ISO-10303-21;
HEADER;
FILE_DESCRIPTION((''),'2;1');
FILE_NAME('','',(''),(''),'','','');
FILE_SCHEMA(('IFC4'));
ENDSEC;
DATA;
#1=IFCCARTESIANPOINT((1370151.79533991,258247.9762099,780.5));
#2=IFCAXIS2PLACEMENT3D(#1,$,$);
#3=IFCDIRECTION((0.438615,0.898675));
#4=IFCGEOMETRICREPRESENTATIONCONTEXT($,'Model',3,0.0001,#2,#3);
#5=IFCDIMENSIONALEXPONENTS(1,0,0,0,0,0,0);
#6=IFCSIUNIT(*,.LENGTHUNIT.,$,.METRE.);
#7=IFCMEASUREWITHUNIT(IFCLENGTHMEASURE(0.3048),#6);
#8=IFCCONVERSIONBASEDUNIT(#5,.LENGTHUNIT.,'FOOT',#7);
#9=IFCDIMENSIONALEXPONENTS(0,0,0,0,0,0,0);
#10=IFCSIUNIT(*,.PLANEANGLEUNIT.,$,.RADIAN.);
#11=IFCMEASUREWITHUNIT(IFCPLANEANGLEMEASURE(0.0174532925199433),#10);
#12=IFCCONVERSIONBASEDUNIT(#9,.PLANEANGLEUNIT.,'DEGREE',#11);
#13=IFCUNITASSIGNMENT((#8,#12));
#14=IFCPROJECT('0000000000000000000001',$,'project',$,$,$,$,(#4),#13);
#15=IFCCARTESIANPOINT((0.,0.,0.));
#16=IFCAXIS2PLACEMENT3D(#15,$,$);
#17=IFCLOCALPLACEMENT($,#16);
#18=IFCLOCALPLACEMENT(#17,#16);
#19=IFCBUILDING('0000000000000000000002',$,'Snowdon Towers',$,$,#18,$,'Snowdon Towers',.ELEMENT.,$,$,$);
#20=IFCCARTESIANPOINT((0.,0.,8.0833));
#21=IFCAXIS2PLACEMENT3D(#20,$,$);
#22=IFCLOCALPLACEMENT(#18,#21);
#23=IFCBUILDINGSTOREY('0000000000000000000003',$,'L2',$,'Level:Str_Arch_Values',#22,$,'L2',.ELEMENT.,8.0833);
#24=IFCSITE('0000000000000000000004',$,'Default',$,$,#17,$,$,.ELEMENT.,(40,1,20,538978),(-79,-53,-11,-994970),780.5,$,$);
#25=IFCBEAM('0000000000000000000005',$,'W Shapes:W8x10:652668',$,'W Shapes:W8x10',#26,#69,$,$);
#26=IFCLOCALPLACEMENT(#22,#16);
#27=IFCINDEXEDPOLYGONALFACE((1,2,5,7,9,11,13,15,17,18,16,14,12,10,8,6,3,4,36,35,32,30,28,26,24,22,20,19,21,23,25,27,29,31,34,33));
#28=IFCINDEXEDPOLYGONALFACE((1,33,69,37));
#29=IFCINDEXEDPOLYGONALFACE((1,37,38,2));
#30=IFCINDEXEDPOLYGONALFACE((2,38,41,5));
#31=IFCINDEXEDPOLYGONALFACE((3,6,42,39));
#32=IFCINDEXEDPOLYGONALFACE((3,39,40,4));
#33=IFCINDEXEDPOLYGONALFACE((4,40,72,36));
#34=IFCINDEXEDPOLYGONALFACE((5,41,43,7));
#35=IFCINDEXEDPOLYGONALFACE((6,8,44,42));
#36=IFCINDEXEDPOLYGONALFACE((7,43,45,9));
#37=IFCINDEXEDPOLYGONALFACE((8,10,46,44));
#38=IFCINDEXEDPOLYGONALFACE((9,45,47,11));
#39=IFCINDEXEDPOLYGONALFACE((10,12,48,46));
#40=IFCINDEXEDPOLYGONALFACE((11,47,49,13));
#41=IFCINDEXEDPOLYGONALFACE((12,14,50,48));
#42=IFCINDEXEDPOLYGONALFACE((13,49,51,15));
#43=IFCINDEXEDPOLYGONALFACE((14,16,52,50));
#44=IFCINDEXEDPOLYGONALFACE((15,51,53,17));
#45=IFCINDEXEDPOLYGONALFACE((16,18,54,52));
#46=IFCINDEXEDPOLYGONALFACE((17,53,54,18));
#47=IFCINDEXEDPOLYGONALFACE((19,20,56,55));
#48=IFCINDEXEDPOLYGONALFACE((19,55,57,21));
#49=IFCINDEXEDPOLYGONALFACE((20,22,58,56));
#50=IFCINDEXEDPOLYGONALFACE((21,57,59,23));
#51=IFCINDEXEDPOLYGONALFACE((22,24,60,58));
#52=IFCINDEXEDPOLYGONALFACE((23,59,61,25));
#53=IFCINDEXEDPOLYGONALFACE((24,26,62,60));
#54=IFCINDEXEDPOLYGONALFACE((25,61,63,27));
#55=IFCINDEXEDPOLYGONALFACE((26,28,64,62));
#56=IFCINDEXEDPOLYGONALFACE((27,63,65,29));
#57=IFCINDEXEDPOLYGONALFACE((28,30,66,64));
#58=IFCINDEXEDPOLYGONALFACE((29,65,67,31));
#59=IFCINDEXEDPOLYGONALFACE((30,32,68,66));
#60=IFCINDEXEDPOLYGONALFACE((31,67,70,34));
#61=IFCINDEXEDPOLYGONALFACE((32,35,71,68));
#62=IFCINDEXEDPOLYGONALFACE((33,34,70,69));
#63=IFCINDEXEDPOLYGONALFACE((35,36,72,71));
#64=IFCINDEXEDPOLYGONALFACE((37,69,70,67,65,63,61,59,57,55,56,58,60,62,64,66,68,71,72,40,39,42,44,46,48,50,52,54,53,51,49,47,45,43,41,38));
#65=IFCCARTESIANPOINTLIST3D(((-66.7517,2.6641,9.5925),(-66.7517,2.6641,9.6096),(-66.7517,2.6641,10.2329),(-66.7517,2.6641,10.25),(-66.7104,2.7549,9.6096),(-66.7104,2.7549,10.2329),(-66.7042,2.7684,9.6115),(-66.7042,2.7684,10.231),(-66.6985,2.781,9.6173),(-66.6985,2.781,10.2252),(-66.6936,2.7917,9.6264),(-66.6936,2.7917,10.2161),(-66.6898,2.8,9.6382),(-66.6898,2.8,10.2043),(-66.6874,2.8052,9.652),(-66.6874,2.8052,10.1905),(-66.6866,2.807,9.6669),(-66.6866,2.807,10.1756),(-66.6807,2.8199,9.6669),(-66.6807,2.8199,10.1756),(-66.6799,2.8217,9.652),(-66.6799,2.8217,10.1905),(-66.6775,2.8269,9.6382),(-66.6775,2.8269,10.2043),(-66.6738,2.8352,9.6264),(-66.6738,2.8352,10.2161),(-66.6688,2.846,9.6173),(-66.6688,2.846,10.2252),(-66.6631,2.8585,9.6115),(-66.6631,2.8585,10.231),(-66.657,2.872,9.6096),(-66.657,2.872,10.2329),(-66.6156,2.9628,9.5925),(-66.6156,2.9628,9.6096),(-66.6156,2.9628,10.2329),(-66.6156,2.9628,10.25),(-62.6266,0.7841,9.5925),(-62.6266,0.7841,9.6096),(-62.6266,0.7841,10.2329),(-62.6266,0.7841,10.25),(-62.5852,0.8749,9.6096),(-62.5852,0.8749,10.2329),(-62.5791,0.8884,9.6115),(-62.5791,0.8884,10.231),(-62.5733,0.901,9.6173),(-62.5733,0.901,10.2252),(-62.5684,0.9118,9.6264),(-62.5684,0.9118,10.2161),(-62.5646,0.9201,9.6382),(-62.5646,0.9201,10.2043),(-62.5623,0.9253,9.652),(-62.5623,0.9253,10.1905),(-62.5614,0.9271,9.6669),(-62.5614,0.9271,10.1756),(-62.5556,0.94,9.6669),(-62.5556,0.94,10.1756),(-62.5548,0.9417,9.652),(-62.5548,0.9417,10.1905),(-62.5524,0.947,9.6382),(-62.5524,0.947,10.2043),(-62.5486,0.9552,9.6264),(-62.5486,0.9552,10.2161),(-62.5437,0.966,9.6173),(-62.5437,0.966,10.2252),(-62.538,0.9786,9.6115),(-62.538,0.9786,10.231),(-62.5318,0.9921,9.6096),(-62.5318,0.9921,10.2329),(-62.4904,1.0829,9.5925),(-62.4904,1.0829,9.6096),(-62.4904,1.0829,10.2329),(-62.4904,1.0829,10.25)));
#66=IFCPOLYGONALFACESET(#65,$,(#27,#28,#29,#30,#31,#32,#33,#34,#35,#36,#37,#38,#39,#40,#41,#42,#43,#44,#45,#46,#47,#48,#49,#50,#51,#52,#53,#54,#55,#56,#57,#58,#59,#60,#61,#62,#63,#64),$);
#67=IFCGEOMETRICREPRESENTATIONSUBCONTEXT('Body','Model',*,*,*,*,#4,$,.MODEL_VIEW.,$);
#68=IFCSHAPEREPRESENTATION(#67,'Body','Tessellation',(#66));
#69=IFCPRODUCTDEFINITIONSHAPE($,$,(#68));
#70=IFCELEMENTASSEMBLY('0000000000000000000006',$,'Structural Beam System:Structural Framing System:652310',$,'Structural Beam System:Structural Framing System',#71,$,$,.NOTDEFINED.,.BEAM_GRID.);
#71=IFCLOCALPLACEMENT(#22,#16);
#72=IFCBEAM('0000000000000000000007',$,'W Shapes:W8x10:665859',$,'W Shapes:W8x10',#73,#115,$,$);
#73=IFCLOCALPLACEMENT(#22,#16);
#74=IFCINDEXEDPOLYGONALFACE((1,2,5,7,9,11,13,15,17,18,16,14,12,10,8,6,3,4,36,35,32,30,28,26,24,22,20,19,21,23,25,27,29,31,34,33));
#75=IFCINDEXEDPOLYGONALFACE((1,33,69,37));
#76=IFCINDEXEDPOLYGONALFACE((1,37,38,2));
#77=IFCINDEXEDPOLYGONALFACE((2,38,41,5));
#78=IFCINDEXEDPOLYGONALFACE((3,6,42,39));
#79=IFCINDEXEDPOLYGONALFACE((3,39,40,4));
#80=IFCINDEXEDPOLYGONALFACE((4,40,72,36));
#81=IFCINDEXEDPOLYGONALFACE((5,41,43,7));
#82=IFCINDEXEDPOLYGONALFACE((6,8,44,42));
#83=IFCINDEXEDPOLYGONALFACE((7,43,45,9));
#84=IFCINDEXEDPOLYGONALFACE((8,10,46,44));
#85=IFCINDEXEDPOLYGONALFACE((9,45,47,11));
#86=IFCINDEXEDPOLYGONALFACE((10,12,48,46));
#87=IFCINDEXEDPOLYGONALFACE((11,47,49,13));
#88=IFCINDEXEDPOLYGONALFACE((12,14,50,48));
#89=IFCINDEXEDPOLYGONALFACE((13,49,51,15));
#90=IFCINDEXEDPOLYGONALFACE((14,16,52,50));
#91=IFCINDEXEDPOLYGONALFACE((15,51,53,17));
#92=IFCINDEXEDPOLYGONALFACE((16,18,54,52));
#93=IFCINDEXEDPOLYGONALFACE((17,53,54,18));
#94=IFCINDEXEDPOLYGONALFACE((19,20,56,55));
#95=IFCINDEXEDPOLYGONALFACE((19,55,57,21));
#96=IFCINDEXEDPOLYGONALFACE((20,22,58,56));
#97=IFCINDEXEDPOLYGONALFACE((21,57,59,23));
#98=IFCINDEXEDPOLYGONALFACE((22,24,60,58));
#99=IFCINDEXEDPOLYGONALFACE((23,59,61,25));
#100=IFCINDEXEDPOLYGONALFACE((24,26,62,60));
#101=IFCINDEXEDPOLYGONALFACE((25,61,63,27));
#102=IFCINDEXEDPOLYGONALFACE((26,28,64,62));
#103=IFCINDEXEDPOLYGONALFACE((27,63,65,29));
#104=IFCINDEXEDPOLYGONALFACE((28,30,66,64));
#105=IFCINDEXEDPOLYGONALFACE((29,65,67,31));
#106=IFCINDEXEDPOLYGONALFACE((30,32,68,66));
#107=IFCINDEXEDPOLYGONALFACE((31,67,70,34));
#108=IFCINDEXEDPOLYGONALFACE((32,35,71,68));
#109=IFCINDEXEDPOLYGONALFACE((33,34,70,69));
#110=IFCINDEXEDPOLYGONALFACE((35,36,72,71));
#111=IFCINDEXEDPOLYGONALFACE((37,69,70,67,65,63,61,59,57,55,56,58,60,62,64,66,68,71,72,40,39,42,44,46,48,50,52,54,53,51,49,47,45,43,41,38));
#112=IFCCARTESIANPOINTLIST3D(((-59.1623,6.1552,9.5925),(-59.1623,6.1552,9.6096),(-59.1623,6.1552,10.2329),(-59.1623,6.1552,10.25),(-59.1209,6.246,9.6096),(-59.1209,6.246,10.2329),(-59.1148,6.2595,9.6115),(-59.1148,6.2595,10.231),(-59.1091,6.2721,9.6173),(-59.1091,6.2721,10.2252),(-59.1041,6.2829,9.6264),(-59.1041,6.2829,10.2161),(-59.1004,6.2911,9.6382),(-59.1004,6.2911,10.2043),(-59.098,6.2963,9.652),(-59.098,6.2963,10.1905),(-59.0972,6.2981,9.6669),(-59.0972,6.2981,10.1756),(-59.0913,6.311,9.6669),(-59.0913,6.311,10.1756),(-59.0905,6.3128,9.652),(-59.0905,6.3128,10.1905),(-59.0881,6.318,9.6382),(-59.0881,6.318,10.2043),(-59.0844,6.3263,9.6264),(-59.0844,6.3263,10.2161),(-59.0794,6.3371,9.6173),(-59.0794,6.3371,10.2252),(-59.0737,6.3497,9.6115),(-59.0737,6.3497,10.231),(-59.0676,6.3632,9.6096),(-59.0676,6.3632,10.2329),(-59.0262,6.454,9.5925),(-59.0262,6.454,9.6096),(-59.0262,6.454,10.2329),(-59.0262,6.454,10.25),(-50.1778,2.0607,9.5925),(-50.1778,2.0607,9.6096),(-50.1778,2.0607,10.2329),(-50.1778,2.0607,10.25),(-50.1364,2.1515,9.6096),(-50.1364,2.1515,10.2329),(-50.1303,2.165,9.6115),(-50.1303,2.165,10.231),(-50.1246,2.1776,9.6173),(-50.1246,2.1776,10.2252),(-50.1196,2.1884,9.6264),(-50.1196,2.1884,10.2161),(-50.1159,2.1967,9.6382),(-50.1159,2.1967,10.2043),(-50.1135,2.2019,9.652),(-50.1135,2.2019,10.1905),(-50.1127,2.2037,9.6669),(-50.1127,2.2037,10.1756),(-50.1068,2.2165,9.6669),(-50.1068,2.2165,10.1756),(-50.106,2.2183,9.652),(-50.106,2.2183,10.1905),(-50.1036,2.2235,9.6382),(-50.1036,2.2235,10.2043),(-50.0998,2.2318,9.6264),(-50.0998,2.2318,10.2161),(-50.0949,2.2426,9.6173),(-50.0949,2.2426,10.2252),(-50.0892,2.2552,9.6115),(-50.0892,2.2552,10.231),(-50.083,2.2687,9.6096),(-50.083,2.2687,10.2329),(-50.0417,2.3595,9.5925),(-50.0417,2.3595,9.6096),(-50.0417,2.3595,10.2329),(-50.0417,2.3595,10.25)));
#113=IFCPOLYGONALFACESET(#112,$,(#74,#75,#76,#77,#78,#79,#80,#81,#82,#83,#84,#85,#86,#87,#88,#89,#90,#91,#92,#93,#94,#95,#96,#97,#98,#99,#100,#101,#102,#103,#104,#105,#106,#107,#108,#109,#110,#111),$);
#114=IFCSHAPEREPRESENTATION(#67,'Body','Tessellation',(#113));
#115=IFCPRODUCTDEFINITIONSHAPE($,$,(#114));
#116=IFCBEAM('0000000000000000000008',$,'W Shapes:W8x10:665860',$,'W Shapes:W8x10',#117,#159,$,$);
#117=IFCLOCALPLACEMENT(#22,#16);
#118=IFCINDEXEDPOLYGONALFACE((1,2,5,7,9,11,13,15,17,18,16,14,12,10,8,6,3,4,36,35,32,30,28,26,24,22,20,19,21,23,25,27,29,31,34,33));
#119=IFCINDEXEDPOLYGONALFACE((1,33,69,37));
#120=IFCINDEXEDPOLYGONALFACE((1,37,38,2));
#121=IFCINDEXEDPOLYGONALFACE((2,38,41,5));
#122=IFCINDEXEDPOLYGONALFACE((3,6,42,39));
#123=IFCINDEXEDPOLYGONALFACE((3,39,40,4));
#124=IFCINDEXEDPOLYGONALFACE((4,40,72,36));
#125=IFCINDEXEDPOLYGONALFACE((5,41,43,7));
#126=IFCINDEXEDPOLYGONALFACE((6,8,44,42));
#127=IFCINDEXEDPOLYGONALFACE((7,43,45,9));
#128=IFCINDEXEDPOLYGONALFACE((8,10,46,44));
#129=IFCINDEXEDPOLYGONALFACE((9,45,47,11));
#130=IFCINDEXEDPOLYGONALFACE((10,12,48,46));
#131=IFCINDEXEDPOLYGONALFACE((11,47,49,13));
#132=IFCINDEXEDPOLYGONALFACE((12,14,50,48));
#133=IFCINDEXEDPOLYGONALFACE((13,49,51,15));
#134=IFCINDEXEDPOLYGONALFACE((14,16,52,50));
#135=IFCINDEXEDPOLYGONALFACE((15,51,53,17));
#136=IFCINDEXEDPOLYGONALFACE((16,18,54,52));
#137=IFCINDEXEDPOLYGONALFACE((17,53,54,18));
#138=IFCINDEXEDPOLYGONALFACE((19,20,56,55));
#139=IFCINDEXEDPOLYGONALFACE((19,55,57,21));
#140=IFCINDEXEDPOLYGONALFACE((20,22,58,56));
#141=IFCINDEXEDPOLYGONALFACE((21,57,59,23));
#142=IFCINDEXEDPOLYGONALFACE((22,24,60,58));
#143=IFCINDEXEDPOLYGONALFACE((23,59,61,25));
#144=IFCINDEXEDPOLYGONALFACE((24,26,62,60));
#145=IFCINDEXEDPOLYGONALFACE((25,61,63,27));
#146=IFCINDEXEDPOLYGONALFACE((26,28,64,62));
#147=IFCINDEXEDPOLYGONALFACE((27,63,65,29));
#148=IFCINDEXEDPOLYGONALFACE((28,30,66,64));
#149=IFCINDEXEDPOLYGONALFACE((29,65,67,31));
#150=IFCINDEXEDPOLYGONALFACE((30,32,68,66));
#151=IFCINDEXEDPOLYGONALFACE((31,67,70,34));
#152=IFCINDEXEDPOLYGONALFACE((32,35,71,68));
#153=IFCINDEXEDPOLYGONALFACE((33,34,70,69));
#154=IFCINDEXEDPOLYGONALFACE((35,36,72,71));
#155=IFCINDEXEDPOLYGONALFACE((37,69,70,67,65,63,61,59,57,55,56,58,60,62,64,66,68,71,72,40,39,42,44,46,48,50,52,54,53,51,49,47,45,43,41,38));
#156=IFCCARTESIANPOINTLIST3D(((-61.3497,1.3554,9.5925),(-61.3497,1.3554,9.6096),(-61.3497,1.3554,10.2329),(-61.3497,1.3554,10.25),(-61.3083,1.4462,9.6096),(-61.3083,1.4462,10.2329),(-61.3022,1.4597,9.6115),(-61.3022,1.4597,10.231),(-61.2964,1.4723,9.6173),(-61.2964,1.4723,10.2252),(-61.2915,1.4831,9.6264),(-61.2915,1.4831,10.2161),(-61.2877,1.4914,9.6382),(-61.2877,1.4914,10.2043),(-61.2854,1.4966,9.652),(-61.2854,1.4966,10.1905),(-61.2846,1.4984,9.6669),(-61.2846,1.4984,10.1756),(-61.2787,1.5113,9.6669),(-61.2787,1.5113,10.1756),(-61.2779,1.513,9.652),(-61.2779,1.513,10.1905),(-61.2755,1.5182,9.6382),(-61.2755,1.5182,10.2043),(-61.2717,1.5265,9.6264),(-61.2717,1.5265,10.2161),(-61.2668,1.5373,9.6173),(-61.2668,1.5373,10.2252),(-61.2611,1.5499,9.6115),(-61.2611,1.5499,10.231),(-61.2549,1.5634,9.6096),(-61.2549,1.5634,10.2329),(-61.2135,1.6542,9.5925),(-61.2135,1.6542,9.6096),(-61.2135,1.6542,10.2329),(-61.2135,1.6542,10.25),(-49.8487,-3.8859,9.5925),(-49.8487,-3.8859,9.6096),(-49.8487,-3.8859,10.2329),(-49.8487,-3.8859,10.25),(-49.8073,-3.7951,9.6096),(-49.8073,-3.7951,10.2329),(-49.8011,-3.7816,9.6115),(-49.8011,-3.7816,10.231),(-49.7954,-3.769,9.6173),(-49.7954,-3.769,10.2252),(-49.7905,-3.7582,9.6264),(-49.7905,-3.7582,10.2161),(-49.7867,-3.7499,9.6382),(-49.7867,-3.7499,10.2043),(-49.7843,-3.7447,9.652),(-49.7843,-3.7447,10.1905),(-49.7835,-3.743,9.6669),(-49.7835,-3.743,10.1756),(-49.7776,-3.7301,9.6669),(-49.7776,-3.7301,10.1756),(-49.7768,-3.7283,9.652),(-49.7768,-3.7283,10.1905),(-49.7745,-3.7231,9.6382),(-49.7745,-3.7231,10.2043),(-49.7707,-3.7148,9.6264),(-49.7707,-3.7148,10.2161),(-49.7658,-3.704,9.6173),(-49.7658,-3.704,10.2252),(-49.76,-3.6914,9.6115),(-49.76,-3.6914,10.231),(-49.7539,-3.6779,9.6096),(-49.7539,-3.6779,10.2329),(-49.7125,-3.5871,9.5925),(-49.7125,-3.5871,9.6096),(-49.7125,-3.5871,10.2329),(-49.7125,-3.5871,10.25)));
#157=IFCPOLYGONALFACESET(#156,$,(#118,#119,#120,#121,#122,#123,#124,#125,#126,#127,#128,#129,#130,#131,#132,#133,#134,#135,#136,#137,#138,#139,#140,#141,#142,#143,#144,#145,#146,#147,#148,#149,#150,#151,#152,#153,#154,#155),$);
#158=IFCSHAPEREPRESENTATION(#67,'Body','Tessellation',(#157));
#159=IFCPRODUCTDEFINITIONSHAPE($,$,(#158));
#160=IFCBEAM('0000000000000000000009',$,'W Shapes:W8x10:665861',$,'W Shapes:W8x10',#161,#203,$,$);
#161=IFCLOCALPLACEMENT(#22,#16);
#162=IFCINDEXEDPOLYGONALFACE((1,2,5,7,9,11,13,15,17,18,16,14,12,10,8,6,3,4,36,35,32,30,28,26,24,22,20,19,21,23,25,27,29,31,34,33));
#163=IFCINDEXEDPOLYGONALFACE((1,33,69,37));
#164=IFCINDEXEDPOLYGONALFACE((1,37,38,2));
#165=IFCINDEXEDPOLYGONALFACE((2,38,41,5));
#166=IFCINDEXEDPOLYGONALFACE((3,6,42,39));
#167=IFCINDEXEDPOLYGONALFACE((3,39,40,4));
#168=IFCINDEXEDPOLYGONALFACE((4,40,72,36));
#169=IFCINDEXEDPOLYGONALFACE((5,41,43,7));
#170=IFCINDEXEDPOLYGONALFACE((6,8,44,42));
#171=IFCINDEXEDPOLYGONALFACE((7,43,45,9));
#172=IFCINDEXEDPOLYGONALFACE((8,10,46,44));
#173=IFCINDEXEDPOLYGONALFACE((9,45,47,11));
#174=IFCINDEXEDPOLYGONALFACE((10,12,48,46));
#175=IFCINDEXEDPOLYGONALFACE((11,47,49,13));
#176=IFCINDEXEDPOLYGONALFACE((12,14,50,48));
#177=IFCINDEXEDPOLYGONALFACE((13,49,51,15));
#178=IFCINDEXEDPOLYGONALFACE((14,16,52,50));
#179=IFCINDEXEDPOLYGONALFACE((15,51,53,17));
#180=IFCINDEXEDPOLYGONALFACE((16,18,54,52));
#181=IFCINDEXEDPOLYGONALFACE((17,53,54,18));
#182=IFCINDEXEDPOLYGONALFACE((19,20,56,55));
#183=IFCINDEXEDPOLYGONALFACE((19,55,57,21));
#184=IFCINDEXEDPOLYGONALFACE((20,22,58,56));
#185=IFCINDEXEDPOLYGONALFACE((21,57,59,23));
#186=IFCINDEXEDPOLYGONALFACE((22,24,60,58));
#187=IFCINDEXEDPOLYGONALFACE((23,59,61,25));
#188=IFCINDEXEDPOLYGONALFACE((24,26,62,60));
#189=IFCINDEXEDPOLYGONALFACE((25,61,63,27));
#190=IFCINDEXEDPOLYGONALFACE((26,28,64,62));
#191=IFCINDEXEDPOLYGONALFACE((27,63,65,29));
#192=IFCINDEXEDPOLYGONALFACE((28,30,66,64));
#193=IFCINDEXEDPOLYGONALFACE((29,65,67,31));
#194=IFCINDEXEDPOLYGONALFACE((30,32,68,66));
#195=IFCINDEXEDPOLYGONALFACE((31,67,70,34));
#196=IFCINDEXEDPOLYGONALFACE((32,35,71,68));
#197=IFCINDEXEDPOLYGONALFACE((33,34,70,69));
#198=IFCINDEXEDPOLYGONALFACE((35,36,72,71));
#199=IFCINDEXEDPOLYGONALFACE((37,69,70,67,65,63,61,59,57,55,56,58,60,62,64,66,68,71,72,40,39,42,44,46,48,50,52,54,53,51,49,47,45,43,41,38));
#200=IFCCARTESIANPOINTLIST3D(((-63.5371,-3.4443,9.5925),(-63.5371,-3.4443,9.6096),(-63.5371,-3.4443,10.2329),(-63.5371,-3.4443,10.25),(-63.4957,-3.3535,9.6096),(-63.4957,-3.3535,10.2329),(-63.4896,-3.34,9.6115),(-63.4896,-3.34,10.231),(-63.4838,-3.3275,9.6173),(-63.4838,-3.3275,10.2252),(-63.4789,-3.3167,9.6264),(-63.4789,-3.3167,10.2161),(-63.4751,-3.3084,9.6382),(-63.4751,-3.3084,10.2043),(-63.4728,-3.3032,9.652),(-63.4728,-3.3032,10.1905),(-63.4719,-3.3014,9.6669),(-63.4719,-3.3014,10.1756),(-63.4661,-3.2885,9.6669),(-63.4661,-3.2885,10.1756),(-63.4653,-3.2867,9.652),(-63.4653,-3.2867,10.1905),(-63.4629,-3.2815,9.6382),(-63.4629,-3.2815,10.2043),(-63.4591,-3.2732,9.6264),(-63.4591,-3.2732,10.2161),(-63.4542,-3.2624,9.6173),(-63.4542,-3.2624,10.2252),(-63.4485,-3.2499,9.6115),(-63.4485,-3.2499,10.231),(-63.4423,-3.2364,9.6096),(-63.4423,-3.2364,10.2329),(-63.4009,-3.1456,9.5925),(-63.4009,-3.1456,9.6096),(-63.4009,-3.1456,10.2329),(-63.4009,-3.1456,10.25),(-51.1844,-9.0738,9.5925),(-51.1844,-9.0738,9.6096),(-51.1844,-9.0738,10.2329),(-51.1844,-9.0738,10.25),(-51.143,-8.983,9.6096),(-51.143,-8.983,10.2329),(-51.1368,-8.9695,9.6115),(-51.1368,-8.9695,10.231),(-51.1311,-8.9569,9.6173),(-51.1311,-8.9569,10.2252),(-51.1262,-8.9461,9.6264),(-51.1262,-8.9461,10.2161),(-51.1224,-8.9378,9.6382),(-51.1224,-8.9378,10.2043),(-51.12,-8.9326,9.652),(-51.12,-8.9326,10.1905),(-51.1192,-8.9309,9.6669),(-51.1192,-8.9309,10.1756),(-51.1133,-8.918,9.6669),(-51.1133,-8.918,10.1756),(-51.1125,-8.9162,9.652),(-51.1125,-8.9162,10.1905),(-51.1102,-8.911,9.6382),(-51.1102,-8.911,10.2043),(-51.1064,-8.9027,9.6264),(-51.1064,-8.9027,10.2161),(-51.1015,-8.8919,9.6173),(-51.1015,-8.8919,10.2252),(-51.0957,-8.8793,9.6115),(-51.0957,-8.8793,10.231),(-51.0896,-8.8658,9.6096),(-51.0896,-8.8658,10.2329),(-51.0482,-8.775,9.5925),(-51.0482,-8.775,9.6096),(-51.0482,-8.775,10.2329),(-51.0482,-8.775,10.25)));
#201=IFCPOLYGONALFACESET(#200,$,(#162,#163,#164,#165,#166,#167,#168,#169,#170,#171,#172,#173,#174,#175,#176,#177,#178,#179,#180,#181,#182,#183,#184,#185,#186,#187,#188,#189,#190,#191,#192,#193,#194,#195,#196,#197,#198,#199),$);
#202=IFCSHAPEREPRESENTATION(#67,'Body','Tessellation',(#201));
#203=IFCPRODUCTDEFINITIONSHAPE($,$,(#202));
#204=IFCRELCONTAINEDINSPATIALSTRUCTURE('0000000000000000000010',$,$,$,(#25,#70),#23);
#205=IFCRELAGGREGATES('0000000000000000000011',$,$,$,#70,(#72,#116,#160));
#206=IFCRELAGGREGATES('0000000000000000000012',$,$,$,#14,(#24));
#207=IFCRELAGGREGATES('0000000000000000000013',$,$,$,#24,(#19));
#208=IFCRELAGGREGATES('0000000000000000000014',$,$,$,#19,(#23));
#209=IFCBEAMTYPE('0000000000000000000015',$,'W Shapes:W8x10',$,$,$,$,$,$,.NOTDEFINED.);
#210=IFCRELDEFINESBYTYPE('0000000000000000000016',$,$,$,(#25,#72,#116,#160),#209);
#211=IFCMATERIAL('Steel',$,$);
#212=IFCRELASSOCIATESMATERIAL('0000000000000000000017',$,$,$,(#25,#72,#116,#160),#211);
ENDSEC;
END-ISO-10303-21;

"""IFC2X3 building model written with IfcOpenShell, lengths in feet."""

from ifc_helpers import new_model, entity, si_unit, converted_unit, direction, frame, frame_2d, origin, place, context, subcontext, project, spatial, i_section, extrude, material, type_object, element, aggregate, save


model = new_model("IFC2X3")

# Units and contexts
model_context = context("Model", 3, precision=0.0001, world=frame((1370151.79533991, 258247.9762099, 780.5)), true_north=direction((0.438615, 0.898675)))
body_context = subcontext(model_context, "Body", "Model", "MODEL_VIEW")
ifc_project = project(units=[converted_unit("LENGTHUNIT", "FOOT", entity("IfcLengthMeasure", 0.3048), si_unit("LENGTHUNIT", "METRE"), dimensions=[1, 0, 0, 0, 0, 0, 0]), converted_unit("PLANEANGLEUNIT", "DEGREE", entity("IfcPlaneAngleMeasure", 0.0174532925199433), si_unit("PLANEANGLEUNIT", "RADIAN"), dimensions=[0, 0, 0, 0, 0, 0, 0])], contexts=[model_context])

# Site, building, storey
site_placement = place(None, origin())
site = spatial("IfcSite", under=ifc_project, at=site_placement, Name="Default", CompositionType="ELEMENT", RefLatitude=(40, 1, 20, 538978), RefLongitude=(-79, -53, -11, -994970), RefElevation=780.5)
building_placement = place(site_placement, origin())
building = spatial("IfcBuilding", under=site, at=building_placement, Name="Snowdon Towers", LongName="Snowdon Towers", CompositionType="ELEMENT")
storey_placement = place(building_placement, frame((0.0, 0.0, 8.0833)))
storey = spatial("IfcBuildingStorey", under=building, at=storey_placement, Name="L2", ObjectType="Level:Str_Arch_Values", LongName="L2", CompositionType="ELEMENT", Elevation=8.0833)

# Shared definitions
ifc_material_1 = material(Name="Steel")

# Shared definitions
beam_type_1 = type_object("IfcBeamType", Name="W Shapes:W8x10", PredefinedType="NOTDEFINED")

# Beam
beam_1_placement = place(storey_placement, frame((-62.1377, 0.7417, 10.25), z_axis=(0.0, 0.0, 1.0), x_axis=(-0.909961, 0.414693, 0.0)))
element("IfcBeam", 1, at=beam_1_placement, inside=storey, type_object=beam_type_1, material=ifc_material_1, Name="W Shapes:W8x10:652668", ObjectType="W Shapes:W8x10", context=body_context, shape_type="SweptSolid", body=[
    extrude(i_section(OverallWidth=0.3283, OverallDepth=0.6575, WebThickness=0.0142, FlangeThickness=0.0171, FilletRadius=0.0573, at=frame_2d((0.0, 0.0), x_axis=(0.0, 1.0))), frame((0.4625, 0.0, -0.3288), z_axis=(1.0, 0.0, 0.0), x_axis=(0.0, 0.0, -1.0)), (0.0, 0.0, 1.0), 4.5333),
])

# Element assembly, beams
assembly_1_placement = place(storey_placement, origin())
assembly_1 = element("IfcElementAssembly", 2, at=assembly_1_placement, inside=storey, Name="Structural Beam System:Structural Framing System:652310", ObjectType="Structural Beam System:Structural Framing System", AssemblyPlace="NOTDEFINED", PredefinedType="BEAM_GRID")
beam_2_placement = place(assembly_1_placement, frame((-59.5151, 6.4964, 10.25), z_axis=(0.0, 0.0, 1.0), x_axis=(0.909961, -0.414693, 0.0)))
beam_2 = element("IfcBeam", 3, at=beam_2_placement, type_object=beam_type_1, material=ifc_material_1, Name="W Shapes:W8x10:665859", ObjectType="W Shapes:W8x10", context=body_context, shape_type="SweptSolid", body=[
    extrude(i_section(OverallWidth=0.3283, OverallDepth=0.6575, WebThickness=0.0142, FlangeThickness=0.0171, FilletRadius=0.0573, at=frame_2d((0.0, 0.0), x_axis=(0.0, 1.0))), frame((0.4625, 0.0, -0.3288), z_axis=(1.0, 0.0, 0.0), x_axis=(0.0, 0.0, -1.0)), (0.0, 0.0, 1.0), 9.8735),
])
beam_3_placement = place(assembly_1_placement, frame((-61.7025, 1.6966, 10.25), z_axis=(0.0, 0.0, 1.0), x_axis=(0.909961, -0.414693, 0.0)))
beam_3 = element("IfcBeam", 4, at=beam_3_placement, type_object=beam_type_1, material=ifc_material_1, Name="W Shapes:W8x10:665860", ObjectType="W Shapes:W8x10", context=body_context, shape_type="SweptSolid", body=[
    extrude(i_section(OverallWidth=0.3283, OverallDepth=0.6575, WebThickness=0.0142, FlangeThickness=0.0171, FilletRadius=0.0573, at=frame_2d((0.0, 0.0), x_axis=(0.0, 1.0))), frame((0.4625, 0.0, -0.3288), z_axis=(1.0, 0.0, 0.0), x_axis=(0.0, 0.0, -1.0)), (0.0, 0.0, 1.0), 12.6391),
])
beam_4_placement = place(assembly_1_placement, frame((-63.8899, -3.1031, 10.25), z_axis=(0.0, 0.0, 1.0), x_axis=(0.909961, -0.414693, 0.0)))
beam_4 = element("IfcBeam", 5, at=beam_4_placement, type_object=beam_type_1, material=ifc_material_1, Name="W Shapes:W8x10:665861", ObjectType="W Shapes:W8x10", context=body_context, shape_type="SweptSolid", body=[
    extrude(i_section(OverallWidth=0.3283, OverallDepth=0.6575, WebThickness=0.0142, FlangeThickness=0.0171, FilletRadius=0.0573, at=frame_2d((0.0, 0.0), x_axis=(0.0, 1.0))), frame((0.4625, 0.0, -0.3288), z_axis=(1.0, 0.0, 0.0), x_axis=(0.0, 0.0, -1.0)), (0.0, 0.0, 1.0), 13.575),
])
aggregate(assembly_1, [beam_2, beam_3, beam_4])

save(model, "model.ifc")
